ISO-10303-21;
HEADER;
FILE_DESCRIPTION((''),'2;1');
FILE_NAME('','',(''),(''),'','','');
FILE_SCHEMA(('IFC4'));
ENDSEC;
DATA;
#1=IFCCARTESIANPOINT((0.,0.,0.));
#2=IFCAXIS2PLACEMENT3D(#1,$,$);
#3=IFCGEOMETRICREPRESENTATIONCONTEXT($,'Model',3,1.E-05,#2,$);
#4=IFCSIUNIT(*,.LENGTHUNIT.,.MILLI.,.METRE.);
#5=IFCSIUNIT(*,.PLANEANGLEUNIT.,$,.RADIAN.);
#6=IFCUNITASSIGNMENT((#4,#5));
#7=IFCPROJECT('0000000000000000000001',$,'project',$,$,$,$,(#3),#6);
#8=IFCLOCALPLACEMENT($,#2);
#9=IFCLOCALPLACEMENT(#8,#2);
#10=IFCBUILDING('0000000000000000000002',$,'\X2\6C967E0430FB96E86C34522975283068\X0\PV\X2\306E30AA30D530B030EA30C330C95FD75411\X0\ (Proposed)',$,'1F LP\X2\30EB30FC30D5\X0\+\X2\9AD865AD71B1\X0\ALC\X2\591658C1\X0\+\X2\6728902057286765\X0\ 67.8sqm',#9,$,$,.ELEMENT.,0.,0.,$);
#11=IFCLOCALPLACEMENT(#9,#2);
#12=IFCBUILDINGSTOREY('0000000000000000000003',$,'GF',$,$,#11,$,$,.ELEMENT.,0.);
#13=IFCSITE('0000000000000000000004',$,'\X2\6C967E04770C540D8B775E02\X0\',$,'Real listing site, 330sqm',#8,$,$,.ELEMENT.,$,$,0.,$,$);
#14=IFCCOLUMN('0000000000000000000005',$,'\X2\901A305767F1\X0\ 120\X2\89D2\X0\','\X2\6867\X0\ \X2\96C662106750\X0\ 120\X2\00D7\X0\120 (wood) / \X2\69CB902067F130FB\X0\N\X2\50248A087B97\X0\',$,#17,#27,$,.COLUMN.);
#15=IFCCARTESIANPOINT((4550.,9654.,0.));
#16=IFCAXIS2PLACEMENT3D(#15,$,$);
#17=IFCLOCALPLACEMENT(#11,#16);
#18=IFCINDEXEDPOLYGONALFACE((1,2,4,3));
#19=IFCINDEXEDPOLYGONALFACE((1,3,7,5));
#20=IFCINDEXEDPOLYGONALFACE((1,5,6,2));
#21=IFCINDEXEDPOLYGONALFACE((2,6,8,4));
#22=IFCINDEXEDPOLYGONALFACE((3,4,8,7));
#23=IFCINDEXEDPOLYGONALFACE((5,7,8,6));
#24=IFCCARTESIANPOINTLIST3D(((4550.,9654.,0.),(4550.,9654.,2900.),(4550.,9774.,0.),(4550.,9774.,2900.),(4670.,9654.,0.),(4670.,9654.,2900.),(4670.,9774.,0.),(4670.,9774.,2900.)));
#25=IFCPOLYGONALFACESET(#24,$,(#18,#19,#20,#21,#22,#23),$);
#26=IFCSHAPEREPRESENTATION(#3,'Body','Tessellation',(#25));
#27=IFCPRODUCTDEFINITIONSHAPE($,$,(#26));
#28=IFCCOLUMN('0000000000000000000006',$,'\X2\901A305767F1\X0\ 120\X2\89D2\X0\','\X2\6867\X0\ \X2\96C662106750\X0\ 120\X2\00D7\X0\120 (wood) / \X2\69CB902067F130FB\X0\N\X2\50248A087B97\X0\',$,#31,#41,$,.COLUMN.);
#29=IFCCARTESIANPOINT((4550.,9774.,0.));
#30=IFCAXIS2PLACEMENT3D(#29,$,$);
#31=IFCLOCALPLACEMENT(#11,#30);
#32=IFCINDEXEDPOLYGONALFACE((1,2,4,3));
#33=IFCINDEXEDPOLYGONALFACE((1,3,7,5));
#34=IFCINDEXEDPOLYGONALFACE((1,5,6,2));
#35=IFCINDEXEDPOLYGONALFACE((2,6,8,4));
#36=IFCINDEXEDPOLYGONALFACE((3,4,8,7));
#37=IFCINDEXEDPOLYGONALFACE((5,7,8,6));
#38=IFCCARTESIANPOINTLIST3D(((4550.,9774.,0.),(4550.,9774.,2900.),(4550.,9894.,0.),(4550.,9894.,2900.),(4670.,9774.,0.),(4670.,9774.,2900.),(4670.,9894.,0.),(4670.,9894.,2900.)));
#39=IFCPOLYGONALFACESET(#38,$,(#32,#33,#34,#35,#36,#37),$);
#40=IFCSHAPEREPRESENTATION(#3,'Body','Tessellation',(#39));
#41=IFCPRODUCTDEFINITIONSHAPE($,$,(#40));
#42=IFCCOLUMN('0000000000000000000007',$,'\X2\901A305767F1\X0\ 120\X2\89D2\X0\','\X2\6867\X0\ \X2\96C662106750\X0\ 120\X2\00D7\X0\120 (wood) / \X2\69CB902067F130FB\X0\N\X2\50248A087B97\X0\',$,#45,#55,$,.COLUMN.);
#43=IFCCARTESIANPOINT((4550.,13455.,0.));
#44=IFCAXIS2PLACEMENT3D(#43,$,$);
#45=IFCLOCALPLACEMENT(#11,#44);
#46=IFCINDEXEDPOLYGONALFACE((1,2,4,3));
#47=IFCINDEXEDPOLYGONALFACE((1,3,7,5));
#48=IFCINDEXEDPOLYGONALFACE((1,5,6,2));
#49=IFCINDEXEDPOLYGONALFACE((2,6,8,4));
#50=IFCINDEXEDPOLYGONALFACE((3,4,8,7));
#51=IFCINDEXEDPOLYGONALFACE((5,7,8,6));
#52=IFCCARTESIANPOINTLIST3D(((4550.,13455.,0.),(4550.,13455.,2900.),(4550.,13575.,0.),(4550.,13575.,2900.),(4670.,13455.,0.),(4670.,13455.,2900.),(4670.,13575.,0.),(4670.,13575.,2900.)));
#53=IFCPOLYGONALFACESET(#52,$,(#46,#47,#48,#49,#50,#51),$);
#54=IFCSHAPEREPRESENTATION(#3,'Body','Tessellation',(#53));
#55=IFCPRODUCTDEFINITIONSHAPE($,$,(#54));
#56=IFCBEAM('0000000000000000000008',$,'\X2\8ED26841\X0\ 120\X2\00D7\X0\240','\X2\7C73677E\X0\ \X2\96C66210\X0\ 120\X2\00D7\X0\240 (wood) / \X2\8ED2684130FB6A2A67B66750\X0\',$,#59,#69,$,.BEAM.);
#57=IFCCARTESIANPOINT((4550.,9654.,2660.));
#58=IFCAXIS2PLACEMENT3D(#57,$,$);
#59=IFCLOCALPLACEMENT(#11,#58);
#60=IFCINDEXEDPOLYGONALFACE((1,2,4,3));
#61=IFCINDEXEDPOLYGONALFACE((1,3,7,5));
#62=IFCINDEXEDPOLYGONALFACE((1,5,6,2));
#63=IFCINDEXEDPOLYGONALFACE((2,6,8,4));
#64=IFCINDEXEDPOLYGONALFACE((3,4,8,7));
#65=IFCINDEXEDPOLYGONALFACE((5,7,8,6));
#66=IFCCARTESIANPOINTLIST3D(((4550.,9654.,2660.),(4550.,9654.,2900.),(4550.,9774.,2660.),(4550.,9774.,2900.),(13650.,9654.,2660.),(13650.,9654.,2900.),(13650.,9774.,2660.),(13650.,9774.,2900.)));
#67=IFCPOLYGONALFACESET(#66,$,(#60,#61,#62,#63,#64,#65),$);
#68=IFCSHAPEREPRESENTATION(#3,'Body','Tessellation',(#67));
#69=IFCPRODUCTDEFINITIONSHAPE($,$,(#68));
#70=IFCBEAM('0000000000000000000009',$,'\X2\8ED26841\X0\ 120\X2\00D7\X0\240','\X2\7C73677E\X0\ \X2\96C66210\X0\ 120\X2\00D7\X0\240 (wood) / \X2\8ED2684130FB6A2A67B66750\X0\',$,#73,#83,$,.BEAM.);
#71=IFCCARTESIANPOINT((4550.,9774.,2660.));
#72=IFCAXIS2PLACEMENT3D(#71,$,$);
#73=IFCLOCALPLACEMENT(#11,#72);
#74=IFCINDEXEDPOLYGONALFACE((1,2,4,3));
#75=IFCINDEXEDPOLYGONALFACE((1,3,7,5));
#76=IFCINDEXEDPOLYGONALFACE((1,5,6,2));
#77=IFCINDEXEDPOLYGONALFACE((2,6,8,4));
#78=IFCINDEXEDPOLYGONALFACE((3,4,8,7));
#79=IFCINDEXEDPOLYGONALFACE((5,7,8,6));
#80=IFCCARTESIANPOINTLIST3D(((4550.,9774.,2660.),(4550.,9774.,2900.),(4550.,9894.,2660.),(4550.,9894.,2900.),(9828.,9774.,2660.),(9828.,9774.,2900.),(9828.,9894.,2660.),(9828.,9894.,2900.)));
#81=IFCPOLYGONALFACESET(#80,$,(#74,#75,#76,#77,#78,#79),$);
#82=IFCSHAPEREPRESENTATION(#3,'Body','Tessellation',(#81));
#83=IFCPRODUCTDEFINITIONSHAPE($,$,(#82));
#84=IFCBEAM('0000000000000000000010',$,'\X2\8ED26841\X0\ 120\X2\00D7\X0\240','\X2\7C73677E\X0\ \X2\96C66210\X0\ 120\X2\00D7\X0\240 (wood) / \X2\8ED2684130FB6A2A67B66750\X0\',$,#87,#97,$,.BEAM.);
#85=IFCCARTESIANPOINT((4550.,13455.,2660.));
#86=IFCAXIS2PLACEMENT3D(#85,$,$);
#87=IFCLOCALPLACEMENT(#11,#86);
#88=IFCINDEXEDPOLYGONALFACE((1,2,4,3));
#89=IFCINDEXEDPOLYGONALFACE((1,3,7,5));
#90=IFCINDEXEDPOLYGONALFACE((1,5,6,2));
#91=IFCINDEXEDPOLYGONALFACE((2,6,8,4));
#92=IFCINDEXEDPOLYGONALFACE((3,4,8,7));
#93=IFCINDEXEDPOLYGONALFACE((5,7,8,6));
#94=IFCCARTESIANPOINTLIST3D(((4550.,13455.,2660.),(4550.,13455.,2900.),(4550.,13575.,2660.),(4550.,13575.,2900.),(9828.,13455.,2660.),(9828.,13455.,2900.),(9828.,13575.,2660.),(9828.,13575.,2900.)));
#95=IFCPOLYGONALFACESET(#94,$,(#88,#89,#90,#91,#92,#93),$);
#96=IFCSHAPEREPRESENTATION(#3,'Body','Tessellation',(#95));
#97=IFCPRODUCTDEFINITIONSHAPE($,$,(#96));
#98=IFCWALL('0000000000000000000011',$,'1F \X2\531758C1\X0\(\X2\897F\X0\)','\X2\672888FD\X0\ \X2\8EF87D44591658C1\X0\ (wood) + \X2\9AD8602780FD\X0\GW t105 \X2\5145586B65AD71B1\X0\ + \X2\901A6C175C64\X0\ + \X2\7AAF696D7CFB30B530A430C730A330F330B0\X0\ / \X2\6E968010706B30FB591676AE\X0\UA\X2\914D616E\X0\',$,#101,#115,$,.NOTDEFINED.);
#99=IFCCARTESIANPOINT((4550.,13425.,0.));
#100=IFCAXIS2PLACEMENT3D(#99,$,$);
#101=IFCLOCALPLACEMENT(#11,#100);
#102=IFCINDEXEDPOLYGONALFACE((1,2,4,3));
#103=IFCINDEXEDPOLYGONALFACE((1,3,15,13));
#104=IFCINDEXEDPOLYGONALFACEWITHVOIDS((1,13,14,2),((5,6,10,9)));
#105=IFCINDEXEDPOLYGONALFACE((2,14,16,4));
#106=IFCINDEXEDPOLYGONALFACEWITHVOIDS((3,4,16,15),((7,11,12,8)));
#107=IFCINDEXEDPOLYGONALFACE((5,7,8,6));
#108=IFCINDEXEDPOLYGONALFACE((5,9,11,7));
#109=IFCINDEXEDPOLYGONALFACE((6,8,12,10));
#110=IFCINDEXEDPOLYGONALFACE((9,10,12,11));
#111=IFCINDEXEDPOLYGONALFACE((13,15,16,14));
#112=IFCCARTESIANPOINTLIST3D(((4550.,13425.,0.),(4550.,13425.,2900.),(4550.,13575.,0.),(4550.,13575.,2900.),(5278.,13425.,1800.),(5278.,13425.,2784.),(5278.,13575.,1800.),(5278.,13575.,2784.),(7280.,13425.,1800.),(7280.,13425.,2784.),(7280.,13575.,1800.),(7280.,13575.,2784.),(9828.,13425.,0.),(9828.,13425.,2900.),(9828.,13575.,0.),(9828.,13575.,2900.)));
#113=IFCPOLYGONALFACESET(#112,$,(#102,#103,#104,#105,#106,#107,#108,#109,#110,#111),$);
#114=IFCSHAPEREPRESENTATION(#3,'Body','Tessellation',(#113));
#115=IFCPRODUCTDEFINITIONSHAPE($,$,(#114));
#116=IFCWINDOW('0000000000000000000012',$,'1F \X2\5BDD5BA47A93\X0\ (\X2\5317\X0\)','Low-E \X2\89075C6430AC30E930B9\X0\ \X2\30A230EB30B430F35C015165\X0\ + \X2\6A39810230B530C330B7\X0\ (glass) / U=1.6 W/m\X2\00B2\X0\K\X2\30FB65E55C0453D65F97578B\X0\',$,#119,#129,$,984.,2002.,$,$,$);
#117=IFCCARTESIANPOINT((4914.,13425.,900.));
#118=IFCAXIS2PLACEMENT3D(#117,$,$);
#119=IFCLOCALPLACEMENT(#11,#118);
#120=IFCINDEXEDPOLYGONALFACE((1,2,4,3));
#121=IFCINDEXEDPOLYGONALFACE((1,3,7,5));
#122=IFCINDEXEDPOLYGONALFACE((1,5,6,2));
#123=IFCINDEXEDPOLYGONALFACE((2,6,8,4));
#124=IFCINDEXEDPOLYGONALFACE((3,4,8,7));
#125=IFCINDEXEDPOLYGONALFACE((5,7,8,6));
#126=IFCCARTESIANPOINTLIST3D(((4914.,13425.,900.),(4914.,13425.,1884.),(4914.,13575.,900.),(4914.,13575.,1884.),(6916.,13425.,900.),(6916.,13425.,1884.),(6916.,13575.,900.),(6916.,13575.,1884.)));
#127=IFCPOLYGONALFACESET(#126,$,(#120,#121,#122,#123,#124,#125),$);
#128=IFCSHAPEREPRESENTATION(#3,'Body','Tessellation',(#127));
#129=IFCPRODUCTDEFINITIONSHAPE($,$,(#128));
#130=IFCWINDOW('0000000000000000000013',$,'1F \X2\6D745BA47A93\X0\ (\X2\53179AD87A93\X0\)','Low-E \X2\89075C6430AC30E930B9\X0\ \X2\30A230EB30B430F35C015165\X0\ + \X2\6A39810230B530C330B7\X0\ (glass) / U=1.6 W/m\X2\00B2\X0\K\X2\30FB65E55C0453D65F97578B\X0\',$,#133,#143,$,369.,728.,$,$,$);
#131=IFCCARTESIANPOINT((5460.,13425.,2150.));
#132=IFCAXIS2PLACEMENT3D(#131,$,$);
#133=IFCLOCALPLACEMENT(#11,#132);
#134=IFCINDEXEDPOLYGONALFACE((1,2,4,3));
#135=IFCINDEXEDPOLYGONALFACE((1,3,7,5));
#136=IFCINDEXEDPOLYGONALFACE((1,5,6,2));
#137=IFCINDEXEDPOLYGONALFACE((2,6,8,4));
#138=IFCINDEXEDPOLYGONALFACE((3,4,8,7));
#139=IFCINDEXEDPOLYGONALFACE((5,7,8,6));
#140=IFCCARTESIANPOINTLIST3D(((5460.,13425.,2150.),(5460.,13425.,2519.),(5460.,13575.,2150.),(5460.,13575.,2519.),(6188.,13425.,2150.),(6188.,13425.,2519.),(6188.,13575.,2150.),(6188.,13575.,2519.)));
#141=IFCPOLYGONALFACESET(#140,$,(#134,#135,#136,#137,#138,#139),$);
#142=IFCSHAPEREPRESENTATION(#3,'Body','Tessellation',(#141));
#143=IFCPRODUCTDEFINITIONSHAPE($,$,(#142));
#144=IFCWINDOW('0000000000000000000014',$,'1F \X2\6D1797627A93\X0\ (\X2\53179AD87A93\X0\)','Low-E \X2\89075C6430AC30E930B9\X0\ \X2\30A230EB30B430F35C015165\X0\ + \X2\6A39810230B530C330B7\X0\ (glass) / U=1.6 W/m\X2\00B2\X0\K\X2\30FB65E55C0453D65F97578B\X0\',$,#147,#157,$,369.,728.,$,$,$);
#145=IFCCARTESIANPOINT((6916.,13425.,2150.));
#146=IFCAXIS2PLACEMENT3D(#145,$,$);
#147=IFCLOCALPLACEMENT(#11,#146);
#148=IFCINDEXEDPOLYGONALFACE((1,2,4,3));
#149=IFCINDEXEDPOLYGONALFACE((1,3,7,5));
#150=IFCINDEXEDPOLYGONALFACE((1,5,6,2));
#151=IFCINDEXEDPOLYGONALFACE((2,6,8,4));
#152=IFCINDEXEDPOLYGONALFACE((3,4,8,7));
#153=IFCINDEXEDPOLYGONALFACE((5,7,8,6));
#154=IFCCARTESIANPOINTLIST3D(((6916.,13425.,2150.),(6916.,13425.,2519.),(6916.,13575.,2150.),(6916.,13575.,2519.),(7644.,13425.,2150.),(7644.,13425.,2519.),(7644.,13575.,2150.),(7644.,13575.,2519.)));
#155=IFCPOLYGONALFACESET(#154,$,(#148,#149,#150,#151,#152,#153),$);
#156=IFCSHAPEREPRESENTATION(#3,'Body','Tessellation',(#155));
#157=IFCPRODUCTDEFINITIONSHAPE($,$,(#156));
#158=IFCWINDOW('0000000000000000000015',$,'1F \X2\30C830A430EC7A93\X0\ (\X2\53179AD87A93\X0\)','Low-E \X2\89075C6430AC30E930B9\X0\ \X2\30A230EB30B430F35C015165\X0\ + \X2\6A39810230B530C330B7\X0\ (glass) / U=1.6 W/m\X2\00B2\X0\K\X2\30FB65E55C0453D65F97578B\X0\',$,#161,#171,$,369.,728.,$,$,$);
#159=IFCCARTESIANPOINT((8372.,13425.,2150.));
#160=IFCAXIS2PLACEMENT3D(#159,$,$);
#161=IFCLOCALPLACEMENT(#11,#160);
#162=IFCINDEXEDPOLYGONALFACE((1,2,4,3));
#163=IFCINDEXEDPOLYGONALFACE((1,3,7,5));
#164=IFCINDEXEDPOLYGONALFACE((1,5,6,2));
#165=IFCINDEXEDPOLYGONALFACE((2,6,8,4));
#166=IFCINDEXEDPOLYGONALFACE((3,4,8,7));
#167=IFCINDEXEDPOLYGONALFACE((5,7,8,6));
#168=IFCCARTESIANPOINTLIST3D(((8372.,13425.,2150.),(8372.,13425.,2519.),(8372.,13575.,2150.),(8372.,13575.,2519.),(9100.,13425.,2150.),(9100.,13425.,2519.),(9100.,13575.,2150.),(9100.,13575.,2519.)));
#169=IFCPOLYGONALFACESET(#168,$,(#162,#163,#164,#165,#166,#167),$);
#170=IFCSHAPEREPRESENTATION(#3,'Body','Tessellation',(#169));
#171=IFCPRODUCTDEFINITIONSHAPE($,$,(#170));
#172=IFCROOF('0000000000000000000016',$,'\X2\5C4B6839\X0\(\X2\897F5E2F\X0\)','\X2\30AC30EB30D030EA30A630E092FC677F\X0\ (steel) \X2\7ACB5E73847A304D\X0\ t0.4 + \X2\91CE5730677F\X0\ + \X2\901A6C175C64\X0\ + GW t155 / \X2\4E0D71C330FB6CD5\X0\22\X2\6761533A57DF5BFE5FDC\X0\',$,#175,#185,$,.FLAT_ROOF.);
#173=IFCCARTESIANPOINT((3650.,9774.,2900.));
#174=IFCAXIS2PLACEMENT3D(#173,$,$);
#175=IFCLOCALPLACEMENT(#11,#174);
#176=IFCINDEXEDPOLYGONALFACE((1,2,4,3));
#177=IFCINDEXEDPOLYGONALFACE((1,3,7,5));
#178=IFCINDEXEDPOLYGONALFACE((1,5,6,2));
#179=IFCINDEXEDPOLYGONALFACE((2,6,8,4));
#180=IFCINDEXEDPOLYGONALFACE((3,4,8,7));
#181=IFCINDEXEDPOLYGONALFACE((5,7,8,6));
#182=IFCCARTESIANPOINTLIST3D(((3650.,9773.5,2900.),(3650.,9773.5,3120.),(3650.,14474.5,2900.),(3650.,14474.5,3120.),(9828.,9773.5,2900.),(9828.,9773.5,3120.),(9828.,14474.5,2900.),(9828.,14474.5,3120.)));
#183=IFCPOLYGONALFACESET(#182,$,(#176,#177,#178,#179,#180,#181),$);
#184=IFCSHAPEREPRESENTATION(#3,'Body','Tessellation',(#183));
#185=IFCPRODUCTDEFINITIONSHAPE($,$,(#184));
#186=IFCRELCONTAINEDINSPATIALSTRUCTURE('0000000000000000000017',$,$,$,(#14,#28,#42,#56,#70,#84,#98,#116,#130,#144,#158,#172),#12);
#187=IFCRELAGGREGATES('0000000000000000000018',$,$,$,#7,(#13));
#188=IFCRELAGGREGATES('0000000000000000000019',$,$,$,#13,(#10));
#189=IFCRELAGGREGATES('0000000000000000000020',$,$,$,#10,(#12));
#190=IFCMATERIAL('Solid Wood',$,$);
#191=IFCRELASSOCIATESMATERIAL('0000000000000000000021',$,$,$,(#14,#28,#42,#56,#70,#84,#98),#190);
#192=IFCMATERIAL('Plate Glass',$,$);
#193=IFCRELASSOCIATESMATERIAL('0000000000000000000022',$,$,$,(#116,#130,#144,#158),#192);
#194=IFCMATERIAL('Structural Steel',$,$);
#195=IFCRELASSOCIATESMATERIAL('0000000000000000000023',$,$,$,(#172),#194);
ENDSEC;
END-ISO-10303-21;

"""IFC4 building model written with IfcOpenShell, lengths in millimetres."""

from ifc_helpers import new_model, si_unit, frame, frame_2d, origin, place, context, project, spatial, rectangle, extrude, material, element, fill, save


model = new_model("IFC4")

# Units and contexts
model_context = context("Model", 3, precision=1e-05, world=origin())
ifc_project = project(units=[si_unit("LENGTHUNIT", "METRE", prefix="MILLI"), si_unit("PLANEANGLEUNIT", "RADIAN")], contexts=[model_context])

# Site, building, storey
site_placement = place(None, origin())
site = spatial("IfcSite", under=ifc_project, at=site_placement, Name="沖縄県名護市", ObjectType="Real listing site, 330sqm", CompositionType="ELEMENT", RefElevation=0.0)
building_placement = place(site_placement, origin())
building = spatial("IfcBuilding", under=site, at=building_placement, Name="沖縄・雨水利用とPVのオフグリッド志向 (Proposed)", ObjectType="1F LPルーフ+高断熱ALC外壁+木造在来 67.8sqm", CompositionType="ELEMENT", ElevationOfRefHeight=0.0, ElevationOfTerrain=0.0)
storey_placement = place(building_placement, origin())
storey = spatial("IfcBuildingStorey", under=building, at=storey_placement, Name="GF", CompositionType="ELEMENT", Elevation=0.0)

# Columns
ifc_material_1 = material(Name="Solid Wood")
column_1_placement = place(storey_placement, frame((4550.0, 9654.0, 0.0)))
element("IfcColumn", 1, at=column_1_placement, inside=storey, material=ifc_material_1, Name="通し柱 120角", Description="桧 集成材 120×120 (wood) / 構造柱・N値計算", PredefinedType="COLUMN", context=model_context, shape_type="SweptSolid", body=[
    extrude(rectangle(XDim=120.0, YDim=120.0, at=frame_2d((60.0, 60.0))), frame((4550.0, 9654.0, 0.0)), (0.0, 0.0, 1.0), 2900.0),
])
column_2_placement = place(storey_placement, frame((4550.0, 9774.0, 0.0)))
element("IfcColumn", 2, at=column_2_placement, inside=storey, material=ifc_material_1, Name="通し柱 120角", Description="桧 集成材 120×120 (wood) / 構造柱・N値計算", PredefinedType="COLUMN", context=model_context, shape_type="SweptSolid", body=[
    extrude(rectangle(XDim=120.0, YDim=120.0, at=frame_2d((60.0, 60.0))), frame((4550.0, 9774.0, 0.0)), (0.0, 0.0, 1.0), 2900.0),
])
column_3_placement = place(storey_placement, frame((4550.0, 13455.0, 0.0)))
element("IfcColumn", 3, at=column_3_placement, inside=storey, material=ifc_material_1, Name="通し柱 120角", Description="桧 集成材 120×120 (wood) / 構造柱・N値計算", PredefinedType="COLUMN", context=model_context, shape_type="SweptSolid", body=[
    extrude(rectangle(XDim=120.0, YDim=120.0, at=frame_2d((60.0, 60.0))), frame((4550.0, 13455.0, 0.0)), (0.0, 0.0, 1.0), 2900.0),
])

# Beams
beam_1_placement = place(storey_placement, frame((4550.0, 9654.0, 2660.0)))
element("IfcBeam", 4, at=beam_1_placement, inside=storey, material=ifc_material_1, Name="軒桁 120×240", Description="米松 集成 120×240 (wood) / 軒桁・横架材", PredefinedType="BEAM", context=model_context, shape_type="SweptSolid", body=[
    extrude(rectangle(XDim=9100.0, YDim=120.0, at=frame_2d((4550.0, 60.0))), frame((4550.0, 9654.0, 2660.0)), (0.0, 0.0, 1.0), 240.0),
])
beam_2_placement = place(storey_placement, frame((4550.0, 9774.0, 2660.0)))
element("IfcBeam", 5, at=beam_2_placement, inside=storey, material=ifc_material_1, Name="軒桁 120×240", Description="米松 集成 120×240 (wood) / 軒桁・横架材", PredefinedType="BEAM", context=model_context, shape_type="SweptSolid", body=[
    extrude(rectangle(XDim=5278.0, YDim=120.0, at=frame_2d((2639.0, 60.0))), frame((4550.0, 9774.0, 2660.0)), (0.0, 0.0, 1.0), 240.0),
])
beam_3_placement = place(storey_placement, frame((4550.0, 13455.0, 2660.0)))
element("IfcBeam", 6, at=beam_3_placement, inside=storey, material=ifc_material_1, Name="軒桁 120×240", Description="米松 集成 120×240 (wood) / 軒桁・横架材", PredefinedType="BEAM", context=model_context, shape_type="SweptSolid", body=[
    extrude(rectangle(XDim=5278.0, YDim=120.0, at=frame_2d((2639.0, 60.0))), frame((4550.0, 13455.0, 2660.0)), (0.0, 0.0, 1.0), 240.0),
])

# Wall, openings, windows
wall_1_placement = place(storey_placement, frame((4550.0, 13425.0, 0.0)))
wall_1 = element("IfcWall", 7, at=wall_1_placement, inside=storey, material=ifc_material_1, Name="1F 北壁(西)", Description="木製 軸組外壁 (wood) + 高性能GW t105 充填断熱 + 通気層 + 窯業系サイディング / 準耐火・外皮UA配慮", PredefinedType="NOTDEFINED", context=model_context, shape_type="SweptSolid", body=[
    extrude(rectangle(XDim=5278.0, YDim=150.0, at=frame_2d((2639.0, 75.0))), frame((4550.0, 13425.0, 0.0)), (0.0, 0.0, 1.0), 2900.0),
])
opening_1_placement = place(storey_placement, frame((4914.0, 13425.0, 900.0)))
opening_1 = element("IfcOpeningElement", 8, at=opening_1_placement, cuts=wall_1, PredefinedType="NOTDEFINED", context=model_context, shape_type="SweptSolid", body=[
    extrude(rectangle(XDim=2002.0, YDim=150.0, at=frame_2d((1001.0, 75.0))), frame((4914.0, 13425.0, 900.0)), (0.0, 0.0, 1.0), 984.0),
])
opening_2_placement = place(storey_placement, frame((5460.0, 13425.0, 2150.0)))
opening_2 = element("IfcOpeningElement", 9, at=opening_2_placement, cuts=wall_1, PredefinedType="NOTDEFINED", context=model_context, shape_type="SweptSolid", body=[
    extrude(rectangle(XDim=728.0, YDim=150.0, at=frame_2d((364.0, 75.0))), frame((5460.0, 13425.0, 2150.0)), (0.0, 0.0, 1.0), 369.0),
])
opening_3_placement = place(storey_placement, frame((6916.0, 13425.0, 2150.0)))
opening_3 = element("IfcOpeningElement", 10, at=opening_3_placement, cuts=wall_1, PredefinedType="NOTDEFINED", context=model_context, shape_type="SweptSolid", body=[
    extrude(rectangle(XDim=728.0, YDim=150.0, at=frame_2d((364.0, 75.0))), frame((6916.0, 13425.0, 2150.0)), (0.0, 0.0, 1.0), 369.0),
])
opening_4_placement = place(storey_placement, frame((8372.0, 13425.0, 2150.0)))
opening_4 = element("IfcOpeningElement", 11, at=opening_4_placement, cuts=wall_1, PredefinedType="NOTDEFINED", context=model_context, shape_type="SweptSolid", body=[
    extrude(rectangle(XDim=728.0, YDim=150.0, at=frame_2d((364.0, 75.0))), frame((8372.0, 13425.0, 2150.0)), (0.0, 0.0, 1.0), 369.0),
])
ifc_material_2 = material(Name="Plate Glass")
window_1_placement = place(storey_placement, frame((4914.0, 13425.0, 900.0)))
window_1 = element("IfcWindow", 12, at=window_1_placement, inside=storey, material=ifc_material_2, Name="1F 寝室窓 (北)", Description="Low-E 複層ガラス アルゴン封入 + 樹脂サッシ (glass) / U=1.6 W/m²K・日射取得型", OverallHeight=984.0, OverallWidth=2002.0, context=model_context, shape_type="SweptSolid", body=[
    extrude(rectangle(XDim=2002.0, YDim=150.0, at=frame_2d((1001.0, 75.0))), frame((4914.0, 13425.0, 900.0)), (0.0, 0.0, 1.0), 984.0),
])
fill(opening_1, window_1)
window_2_placement = place(storey_placement, frame((5460.0, 13425.0, 2150.0)))
window_2 = element("IfcWindow", 13, at=window_2_placement, inside=storey, material=ifc_material_2, Name="1F 浴室窓 (北高窓)", Description="Low-E 複層ガラス アルゴン封入 + 樹脂サッシ (glass) / U=1.6 W/m²K・日射取得型", OverallHeight=369.0, OverallWidth=728.0, context=model_context, shape_type="SweptSolid", body=[
    extrude(rectangle(XDim=728.0, YDim=150.0, at=frame_2d((364.0, 75.0))), frame((5460.0, 13425.0, 2150.0)), (0.0, 0.0, 1.0), 369.0),
])
fill(opening_2, window_2)
window_3_placement = place(storey_placement, frame((6916.0, 13425.0, 2150.0)))
window_3 = element("IfcWindow", 14, at=window_3_placement, inside=storey, material=ifc_material_2, Name="1F 洗面窓 (北高窓)", Description="Low-E 複層ガラス アルゴン封入 + 樹脂サッシ (glass) / U=1.6 W/m²K・日射取得型", OverallHeight=369.0, OverallWidth=728.0, context=model_context, shape_type="SweptSolid", body=[
    extrude(rectangle(XDim=728.0, YDim=150.0, at=frame_2d((364.0, 75.0))), frame((6916.0, 13425.0, 2150.0)), (0.0, 0.0, 1.0), 369.0),
])
fill(opening_3, window_3)
window_4_placement = place(storey_placement, frame((8372.0, 13425.0, 2150.0)))
window_4 = element("IfcWindow", 15, at=window_4_placement, inside=storey, material=ifc_material_2, Name="1F トイレ窓 (北高窓)", Description="Low-E 複層ガラス アルゴン封入 + 樹脂サッシ (glass) / U=1.6 W/m²K・日射取得型", OverallHeight=369.0, OverallWidth=728.0, context=model_context, shape_type="SweptSolid", body=[
    extrude(rectangle(XDim=728.0, YDim=150.0, at=frame_2d((364.0, 75.0))), frame((8372.0, 13425.0, 2150.0)), (0.0, 0.0, 1.0), 369.0),
])
fill(opening_4, window_4)

# Roof
ifc_material_3 = material(Name="Structural Steel")
roof_placement = place(storey_placement, frame((3650.0, 9774.0, 2900.0)))
element("IfcRoof", 16, at=roof_placement, inside=storey, material=ifc_material_3, Name="屋根(西帯)", Description="ガルバリウム鋼板 (steel) 立平葺き t0.4 + 野地板 + 通気層 + GW t155 / 不燃・法22条区域対応", PredefinedType="FLAT_ROOF", context=model_context, shape_type="SweptSolid", body=[
    extrude(rectangle(XDim=6178.0, YDim=4701.0, at=frame_2d((3089.0, 2350.0))), frame((3650.0, 9774.0, 2900.0)), (0.0, 0.0, 1.0), 220.0),
])

save(model, "model.ifc")
